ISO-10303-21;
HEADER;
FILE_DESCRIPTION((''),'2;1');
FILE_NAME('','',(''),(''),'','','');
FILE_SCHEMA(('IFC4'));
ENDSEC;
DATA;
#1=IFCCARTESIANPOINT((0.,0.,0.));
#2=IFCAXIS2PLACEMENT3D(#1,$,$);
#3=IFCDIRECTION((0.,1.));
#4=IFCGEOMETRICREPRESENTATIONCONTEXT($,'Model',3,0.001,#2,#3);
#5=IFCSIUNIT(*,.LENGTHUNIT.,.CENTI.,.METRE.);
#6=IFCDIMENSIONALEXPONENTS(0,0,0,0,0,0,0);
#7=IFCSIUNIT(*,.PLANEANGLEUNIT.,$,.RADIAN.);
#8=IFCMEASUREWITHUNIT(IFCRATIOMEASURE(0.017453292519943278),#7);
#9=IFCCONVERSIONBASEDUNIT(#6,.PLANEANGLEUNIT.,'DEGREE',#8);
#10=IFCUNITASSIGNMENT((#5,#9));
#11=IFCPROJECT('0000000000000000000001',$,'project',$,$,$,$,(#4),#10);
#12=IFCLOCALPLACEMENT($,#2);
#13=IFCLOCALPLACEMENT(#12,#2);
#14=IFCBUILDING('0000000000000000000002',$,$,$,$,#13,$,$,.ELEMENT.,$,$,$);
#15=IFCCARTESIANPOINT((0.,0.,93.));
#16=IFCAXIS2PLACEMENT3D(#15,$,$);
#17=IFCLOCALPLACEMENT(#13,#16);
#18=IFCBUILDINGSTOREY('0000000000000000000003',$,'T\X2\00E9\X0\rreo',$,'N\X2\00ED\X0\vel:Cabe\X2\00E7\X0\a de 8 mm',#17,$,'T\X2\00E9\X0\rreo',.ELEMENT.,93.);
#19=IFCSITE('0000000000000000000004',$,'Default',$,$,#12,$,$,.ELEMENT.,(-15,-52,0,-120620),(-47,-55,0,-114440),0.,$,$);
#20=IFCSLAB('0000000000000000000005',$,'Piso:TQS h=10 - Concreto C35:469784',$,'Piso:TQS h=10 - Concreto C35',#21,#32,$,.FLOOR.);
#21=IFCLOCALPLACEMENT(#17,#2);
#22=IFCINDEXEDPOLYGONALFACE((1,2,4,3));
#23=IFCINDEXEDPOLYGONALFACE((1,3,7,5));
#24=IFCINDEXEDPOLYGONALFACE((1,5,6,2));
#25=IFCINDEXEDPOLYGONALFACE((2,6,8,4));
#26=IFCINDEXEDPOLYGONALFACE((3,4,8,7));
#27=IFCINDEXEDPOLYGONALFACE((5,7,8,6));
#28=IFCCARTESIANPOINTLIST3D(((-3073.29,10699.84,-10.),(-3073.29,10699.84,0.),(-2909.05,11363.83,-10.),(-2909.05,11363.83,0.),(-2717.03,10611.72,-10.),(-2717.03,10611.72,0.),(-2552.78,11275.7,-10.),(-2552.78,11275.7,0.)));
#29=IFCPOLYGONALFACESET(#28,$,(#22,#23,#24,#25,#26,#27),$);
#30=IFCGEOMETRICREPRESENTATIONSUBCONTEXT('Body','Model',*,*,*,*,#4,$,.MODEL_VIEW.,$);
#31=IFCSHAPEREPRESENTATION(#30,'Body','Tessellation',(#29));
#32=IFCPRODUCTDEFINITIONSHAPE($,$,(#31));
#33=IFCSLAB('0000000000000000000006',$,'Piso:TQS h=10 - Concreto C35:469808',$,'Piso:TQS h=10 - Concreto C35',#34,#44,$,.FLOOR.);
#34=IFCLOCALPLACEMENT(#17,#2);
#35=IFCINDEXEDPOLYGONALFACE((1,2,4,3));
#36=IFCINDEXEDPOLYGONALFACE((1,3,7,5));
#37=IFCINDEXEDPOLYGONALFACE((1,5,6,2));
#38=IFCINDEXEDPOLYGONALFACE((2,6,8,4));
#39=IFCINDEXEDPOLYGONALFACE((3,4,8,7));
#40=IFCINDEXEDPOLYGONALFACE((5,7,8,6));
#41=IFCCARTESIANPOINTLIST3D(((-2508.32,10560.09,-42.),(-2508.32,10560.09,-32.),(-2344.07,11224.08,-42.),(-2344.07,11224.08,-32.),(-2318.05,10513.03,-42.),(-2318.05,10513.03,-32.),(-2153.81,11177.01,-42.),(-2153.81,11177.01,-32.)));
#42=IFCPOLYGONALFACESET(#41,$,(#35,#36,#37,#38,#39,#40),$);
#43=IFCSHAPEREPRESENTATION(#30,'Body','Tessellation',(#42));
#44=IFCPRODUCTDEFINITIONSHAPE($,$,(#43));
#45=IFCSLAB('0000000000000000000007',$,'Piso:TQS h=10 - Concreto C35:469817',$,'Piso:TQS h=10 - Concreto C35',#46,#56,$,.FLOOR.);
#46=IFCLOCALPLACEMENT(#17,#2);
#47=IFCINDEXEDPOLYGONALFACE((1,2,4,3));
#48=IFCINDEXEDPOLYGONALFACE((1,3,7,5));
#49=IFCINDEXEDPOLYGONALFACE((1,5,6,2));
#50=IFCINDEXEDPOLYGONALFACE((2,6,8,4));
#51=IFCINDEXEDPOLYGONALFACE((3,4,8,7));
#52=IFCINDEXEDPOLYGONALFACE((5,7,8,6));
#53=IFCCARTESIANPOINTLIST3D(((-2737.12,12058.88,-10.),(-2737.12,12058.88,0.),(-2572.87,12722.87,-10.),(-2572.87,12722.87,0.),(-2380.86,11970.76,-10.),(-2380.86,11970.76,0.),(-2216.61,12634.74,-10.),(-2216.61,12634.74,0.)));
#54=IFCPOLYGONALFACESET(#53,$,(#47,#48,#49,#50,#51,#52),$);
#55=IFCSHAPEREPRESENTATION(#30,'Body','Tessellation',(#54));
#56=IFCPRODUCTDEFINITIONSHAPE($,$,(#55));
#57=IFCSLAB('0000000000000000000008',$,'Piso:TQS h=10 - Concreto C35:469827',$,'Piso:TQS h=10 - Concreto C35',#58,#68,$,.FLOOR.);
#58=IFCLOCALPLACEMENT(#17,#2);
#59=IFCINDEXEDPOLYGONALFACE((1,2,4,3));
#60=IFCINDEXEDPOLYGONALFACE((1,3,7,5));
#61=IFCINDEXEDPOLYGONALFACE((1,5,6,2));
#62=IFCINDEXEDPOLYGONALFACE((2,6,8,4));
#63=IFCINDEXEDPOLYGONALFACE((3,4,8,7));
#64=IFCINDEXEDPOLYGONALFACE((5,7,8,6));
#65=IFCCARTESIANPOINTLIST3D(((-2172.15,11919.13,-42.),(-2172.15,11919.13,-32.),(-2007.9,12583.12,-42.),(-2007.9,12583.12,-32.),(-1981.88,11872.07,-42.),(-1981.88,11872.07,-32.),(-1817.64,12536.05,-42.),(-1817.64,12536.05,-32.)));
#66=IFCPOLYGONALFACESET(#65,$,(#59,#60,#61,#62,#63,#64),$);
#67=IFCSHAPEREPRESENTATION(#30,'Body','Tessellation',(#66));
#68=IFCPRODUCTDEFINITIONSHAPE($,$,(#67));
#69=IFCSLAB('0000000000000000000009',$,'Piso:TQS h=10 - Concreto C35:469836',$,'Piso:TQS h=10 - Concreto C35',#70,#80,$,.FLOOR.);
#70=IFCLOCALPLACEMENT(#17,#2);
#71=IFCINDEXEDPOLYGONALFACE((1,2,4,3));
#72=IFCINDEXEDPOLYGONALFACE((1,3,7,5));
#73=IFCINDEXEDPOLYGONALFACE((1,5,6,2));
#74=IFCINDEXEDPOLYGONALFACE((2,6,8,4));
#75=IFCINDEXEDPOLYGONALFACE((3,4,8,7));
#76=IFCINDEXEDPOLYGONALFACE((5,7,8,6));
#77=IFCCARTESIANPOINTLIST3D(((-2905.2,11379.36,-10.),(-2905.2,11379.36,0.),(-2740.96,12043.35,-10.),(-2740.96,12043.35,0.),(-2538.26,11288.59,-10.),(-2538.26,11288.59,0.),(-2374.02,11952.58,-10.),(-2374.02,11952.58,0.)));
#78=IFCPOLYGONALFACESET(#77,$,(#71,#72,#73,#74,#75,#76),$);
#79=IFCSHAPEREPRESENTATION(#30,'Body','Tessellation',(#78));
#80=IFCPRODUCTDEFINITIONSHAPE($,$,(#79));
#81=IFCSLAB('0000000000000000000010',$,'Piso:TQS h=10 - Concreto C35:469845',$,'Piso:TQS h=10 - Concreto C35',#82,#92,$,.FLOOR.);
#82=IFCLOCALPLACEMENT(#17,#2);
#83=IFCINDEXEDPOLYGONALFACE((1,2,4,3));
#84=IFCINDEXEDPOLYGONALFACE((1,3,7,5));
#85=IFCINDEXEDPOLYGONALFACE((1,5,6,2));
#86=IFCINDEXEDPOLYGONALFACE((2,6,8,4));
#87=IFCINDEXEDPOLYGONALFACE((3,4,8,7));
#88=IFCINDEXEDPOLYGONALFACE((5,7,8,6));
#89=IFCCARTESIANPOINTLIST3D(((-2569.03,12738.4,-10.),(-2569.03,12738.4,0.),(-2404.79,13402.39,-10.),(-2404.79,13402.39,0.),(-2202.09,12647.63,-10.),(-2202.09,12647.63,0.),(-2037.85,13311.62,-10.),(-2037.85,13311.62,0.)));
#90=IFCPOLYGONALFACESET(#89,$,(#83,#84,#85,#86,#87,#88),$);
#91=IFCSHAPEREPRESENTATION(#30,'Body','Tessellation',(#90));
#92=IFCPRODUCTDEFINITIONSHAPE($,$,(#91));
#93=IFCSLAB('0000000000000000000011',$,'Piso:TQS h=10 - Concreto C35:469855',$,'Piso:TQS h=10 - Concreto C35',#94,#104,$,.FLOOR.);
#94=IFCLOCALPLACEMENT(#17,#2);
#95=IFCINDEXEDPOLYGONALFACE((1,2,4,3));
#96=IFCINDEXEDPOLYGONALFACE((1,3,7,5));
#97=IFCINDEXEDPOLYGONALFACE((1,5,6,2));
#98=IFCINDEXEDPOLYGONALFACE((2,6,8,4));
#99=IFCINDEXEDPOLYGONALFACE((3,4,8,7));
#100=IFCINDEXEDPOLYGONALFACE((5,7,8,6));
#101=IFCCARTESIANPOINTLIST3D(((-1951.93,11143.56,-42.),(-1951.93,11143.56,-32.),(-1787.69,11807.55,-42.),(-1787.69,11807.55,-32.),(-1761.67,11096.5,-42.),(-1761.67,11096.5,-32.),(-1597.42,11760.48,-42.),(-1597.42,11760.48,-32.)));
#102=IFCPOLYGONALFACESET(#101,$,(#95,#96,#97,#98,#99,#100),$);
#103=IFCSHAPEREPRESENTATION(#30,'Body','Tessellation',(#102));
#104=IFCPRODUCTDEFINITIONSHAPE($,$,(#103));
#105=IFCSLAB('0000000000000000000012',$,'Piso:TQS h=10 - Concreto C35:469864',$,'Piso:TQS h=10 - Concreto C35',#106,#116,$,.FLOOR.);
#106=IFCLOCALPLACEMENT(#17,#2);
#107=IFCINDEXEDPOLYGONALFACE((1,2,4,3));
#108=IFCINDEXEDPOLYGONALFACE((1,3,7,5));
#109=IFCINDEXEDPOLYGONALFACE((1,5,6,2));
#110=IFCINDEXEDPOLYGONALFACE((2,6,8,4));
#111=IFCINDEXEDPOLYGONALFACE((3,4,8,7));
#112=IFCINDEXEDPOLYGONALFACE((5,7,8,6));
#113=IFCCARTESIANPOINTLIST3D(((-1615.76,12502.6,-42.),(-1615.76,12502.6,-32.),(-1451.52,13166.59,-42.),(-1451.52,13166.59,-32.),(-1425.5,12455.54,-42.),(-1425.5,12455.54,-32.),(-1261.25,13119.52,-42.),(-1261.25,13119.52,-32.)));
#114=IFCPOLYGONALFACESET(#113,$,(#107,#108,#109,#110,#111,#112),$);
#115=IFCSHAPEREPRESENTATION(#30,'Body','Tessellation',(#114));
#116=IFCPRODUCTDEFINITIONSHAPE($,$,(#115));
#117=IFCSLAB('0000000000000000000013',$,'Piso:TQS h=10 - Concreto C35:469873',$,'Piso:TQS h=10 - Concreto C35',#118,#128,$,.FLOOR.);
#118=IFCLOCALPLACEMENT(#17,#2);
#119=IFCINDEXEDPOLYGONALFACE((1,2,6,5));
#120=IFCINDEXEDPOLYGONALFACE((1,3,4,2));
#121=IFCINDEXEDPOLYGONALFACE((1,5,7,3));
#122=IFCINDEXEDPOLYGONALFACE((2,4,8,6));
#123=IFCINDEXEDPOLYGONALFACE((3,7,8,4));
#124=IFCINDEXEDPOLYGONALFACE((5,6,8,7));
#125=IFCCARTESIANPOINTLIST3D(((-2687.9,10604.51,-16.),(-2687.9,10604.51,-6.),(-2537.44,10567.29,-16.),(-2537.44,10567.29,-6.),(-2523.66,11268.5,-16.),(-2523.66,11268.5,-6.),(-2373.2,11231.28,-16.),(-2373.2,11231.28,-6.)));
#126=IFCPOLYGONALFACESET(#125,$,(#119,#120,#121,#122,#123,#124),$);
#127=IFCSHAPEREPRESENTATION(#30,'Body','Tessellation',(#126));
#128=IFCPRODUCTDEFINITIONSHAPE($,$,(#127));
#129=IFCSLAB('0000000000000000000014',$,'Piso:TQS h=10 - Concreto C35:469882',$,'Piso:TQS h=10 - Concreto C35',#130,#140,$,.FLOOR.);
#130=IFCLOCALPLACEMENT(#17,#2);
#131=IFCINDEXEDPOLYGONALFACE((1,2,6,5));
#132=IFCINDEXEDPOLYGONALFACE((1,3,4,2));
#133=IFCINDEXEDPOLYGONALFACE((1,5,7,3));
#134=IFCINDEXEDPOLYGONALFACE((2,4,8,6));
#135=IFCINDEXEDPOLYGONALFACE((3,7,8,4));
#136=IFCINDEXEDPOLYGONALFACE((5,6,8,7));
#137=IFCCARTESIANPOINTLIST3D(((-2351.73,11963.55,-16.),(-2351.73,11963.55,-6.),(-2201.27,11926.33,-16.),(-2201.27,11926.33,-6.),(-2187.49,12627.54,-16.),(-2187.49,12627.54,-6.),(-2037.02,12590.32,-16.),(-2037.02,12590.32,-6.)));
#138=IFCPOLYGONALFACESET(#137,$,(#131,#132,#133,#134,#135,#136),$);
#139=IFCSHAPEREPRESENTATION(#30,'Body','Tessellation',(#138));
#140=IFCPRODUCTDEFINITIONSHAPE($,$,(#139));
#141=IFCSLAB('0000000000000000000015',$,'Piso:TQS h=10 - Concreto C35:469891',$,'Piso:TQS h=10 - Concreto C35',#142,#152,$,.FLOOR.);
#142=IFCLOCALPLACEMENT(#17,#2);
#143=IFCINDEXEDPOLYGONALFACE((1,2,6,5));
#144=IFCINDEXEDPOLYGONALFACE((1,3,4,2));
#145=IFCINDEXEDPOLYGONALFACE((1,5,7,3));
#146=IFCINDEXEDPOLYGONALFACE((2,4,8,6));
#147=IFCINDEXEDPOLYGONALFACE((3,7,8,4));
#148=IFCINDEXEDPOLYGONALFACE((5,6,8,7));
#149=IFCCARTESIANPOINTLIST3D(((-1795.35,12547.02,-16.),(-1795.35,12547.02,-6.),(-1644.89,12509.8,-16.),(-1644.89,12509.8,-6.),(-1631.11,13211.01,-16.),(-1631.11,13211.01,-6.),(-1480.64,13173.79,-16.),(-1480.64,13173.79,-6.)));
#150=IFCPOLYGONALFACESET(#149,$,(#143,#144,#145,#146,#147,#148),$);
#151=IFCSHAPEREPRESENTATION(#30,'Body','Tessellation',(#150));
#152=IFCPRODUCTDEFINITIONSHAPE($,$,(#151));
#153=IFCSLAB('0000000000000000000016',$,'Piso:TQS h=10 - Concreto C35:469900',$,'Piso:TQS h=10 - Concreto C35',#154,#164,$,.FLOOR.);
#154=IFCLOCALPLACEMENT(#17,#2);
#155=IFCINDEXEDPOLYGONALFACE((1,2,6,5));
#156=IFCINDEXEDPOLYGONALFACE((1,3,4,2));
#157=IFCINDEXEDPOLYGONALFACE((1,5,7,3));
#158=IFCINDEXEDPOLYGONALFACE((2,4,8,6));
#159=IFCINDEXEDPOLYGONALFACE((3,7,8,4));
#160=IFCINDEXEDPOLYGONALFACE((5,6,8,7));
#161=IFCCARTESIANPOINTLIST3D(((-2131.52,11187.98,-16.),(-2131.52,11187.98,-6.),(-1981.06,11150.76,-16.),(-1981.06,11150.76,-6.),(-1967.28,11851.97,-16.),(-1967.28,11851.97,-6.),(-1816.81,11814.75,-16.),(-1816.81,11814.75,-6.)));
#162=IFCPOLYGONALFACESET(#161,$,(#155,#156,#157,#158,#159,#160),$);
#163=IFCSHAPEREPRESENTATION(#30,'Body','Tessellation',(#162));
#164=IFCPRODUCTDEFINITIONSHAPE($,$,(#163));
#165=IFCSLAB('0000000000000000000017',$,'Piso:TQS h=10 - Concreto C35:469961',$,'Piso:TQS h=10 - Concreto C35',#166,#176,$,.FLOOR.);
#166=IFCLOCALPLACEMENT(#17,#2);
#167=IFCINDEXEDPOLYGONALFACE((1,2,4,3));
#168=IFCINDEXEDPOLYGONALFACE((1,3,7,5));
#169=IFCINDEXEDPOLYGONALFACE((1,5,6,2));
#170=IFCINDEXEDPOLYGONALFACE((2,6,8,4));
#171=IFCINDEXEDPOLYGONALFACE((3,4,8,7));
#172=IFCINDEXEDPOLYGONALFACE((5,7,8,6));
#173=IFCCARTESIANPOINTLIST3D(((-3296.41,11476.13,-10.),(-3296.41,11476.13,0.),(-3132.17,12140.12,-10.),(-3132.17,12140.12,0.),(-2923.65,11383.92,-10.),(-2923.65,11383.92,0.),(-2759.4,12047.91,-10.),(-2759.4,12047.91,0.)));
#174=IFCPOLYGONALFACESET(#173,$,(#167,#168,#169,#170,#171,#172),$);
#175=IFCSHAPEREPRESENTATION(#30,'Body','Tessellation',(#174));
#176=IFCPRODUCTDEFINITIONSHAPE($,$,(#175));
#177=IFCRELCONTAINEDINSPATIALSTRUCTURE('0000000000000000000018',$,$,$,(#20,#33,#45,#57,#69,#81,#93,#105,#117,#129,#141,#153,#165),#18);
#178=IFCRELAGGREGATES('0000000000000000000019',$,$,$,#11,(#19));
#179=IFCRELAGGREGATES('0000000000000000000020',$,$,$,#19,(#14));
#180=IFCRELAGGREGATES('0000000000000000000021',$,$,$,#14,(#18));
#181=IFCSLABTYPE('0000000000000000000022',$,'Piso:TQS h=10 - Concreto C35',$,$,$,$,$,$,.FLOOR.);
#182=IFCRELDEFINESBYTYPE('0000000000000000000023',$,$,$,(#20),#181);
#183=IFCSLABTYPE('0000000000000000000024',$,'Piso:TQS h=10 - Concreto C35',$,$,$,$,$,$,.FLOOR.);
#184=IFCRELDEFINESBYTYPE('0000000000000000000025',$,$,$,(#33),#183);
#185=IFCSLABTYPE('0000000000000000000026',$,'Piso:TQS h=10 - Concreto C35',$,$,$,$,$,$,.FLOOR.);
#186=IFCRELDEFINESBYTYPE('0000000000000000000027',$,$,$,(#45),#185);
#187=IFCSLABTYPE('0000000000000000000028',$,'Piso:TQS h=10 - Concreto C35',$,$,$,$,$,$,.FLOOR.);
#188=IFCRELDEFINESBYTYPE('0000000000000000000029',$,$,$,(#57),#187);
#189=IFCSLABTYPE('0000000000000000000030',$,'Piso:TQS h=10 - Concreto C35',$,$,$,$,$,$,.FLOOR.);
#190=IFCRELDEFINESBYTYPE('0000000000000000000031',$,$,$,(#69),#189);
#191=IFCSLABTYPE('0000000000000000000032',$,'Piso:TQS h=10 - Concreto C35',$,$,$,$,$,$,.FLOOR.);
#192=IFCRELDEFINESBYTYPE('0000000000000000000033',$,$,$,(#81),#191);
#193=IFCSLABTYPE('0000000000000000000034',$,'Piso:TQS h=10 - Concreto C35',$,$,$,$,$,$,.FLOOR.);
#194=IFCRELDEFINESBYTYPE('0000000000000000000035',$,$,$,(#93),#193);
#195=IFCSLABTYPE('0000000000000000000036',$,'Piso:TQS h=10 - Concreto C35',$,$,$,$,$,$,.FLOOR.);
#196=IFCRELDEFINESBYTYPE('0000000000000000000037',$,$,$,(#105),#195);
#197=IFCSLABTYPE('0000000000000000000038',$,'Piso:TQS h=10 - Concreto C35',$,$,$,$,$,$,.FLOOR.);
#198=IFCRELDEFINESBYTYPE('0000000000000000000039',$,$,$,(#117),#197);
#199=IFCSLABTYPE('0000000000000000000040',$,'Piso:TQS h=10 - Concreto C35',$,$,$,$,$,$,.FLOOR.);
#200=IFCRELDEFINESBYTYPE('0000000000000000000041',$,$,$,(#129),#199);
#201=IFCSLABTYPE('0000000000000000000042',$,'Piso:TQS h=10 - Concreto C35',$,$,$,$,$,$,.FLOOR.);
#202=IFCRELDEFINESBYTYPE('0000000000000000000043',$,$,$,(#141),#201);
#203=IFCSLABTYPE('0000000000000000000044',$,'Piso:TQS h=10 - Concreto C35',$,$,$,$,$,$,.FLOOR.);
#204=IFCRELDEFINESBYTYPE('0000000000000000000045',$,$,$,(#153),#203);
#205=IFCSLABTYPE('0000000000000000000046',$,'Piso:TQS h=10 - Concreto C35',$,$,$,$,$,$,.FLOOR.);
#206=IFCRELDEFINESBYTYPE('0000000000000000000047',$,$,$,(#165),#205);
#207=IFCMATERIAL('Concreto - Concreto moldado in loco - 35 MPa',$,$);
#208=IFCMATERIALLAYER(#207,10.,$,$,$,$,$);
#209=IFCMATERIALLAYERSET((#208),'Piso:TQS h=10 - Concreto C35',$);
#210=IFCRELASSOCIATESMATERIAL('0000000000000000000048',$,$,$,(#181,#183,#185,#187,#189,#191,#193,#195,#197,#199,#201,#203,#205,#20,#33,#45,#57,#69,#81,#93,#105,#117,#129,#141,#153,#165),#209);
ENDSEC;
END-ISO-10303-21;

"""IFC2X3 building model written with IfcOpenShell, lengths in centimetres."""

from ifc_helpers import new_model, entity, si_unit, converted_unit, direction, frame, frame_2d, origin, origin_2d_with_axis, place, context, subcontext, project, spatial, rectangle, extrude, material, layer, layer_set, layer_usage, type_object, element, save


model = new_model("IFC2X3")

# Units and contexts
model_context = context("Model", 3, precision=0.001, world=origin(), true_north=direction((0.0, 1.0)))
body_context = subcontext(model_context, "Body", "Model", "MODEL_VIEW")
ifc_project = project(units=[si_unit("LENGTHUNIT", "METRE", prefix="CENTI"), converted_unit("PLANEANGLEUNIT", "DEGREE", entity("IfcRatioMeasure", 0.017453292519943278), si_unit("PLANEANGLEUNIT", "RADIAN"), dimensions=[0, 0, 0, 0, 0, 0, 0])], contexts=[model_context])

# Site, building, storey
site_placement = place(None, origin())
site = spatial("IfcSite", under=ifc_project, at=site_placement, Name="Default", CompositionType="ELEMENT", RefLatitude=(-15, -52, 0, -120620), RefLongitude=(-47, -55, 0, -114440), RefElevation=0.0)
building_placement = place(site_placement, origin())
building = spatial("IfcBuilding", under=site, at=building_placement, CompositionType="ELEMENT")
storey_placement = place(building_placement, frame((0.0, 0.0, 93.0)))
storey = spatial("IfcBuildingStorey", under=building, at=storey_placement, Name="Térreo", ObjectType="Nível:Cabeça de 8 mm", LongName="Térreo", CompositionType="ELEMENT", Elevation=93.0)

# Shared definitions
ifc_material = material(Name="Concreto - Concreto moldado in loco - 35 MPa")

# Slabs
ifc_layer = layer(ifc_material, 10.0)
ifc_layer_set = layer_set([ifc_layer], Name="Piso:TQS h=10 - Concreto C35")
ifc_layer_usage_1 = layer_usage(ifc_layer_set, "AXIS3", "POSITIVE", 0.0)
slab_type_1 = type_object("IfcSlabType", Name="Piso:TQS h=10 - Concreto C35", PredefinedType="FLOOR", material=ifc_layer_set)
slab_1_placement = place(storey_placement, origin())
element("IfcSlab", 1, at=slab_1_placement, inside=storey, type_object=slab_type_1, material=ifc_layer_usage_1, Name="Piso:TQS h=10 - Concreto C35:469784", ObjectType="Piso:TQS h=10 - Concreto C35", PredefinedType="FLOOR", context=body_context, shape_type="SweptSolid", body=[
    extrude(rectangle(XDim=684.0, YDim=367.0, at=frame_2d((0.0, 0.0), x_axis=(1.0, 0.0))), frame((-2813.04, 10987.77, 0.0), z_axis=(0.0, 0.0, -1.0), x_axis=(-0.240122, -0.970743, 0.0)), (0.0, 0.0, 1.0), 10.0),
])
ifc_layer_usage_2 = layer_usage(ifc_layer_set, "AXIS3", "POSITIVE", 0.0)
slab_type_2 = type_object("IfcSlabType", Name="Piso:TQS h=10 - Concreto C35", PredefinedType="FLOOR", material=ifc_layer_set)
slab_2_placement = place(storey_placement, origin())
element("IfcSlab", 2, at=slab_2_placement, inside=storey, type_object=slab_type_2, material=ifc_layer_usage_2, Name="Piso:TQS h=10 - Concreto C35:469808", ObjectType="Piso:TQS h=10 - Concreto C35", PredefinedType="FLOOR", context=body_context, shape_type="SweptSolid", body=[
    extrude(rectangle(XDim=684.0, YDim=196.0, at=origin_2d_with_axis()), frame((-2331.06, 10868.55, -32.0), z_axis=(0.0, 0.0, -1.0), x_axis=(-0.240122, -0.970743, 0.0)), (0.0, 0.0, 1.0), 10.0),
])
ifc_layer_usage_3 = layer_usage(ifc_layer_set, "AXIS3", "POSITIVE", 0.0)
slab_type_3 = type_object("IfcSlabType", Name="Piso:TQS h=10 - Concreto C35", PredefinedType="FLOOR", material=ifc_layer_set)
slab_3_placement = place(storey_placement, origin())
element("IfcSlab", 3, at=slab_3_placement, inside=storey, type_object=slab_type_3, material=ifc_layer_usage_3, Name="Piso:TQS h=10 - Concreto C35:469817", ObjectType="Piso:TQS h=10 - Concreto C35", PredefinedType="FLOOR", context=body_context, shape_type="SweptSolid", body=[
    extrude(rectangle(XDim=684.0, YDim=367.0, at=frame_2d((0.0, 0.0), x_axis=(1.0, 0.0))), frame((-2476.87, 12346.81, 0.0), z_axis=(0.0, 0.0, -1.0), x_axis=(-0.240122, -0.970743, 0.0)), (0.0, 0.0, 1.0), 10.0),
])
ifc_layer_usage_4 = layer_usage(ifc_layer_set, "AXIS3", "POSITIVE", 0.0)
slab_type_4 = type_object("IfcSlabType", Name="Piso:TQS h=10 - Concreto C35", PredefinedType="FLOOR", material=ifc_layer_set)
slab_4_placement = place(storey_placement, origin())
element("IfcSlab", 4, at=slab_4_placement, inside=storey, type_object=slab_type_4, material=ifc_layer_usage_4, Name="Piso:TQS h=10 - Concreto C35:469827", ObjectType="Piso:TQS h=10 - Concreto C35", PredefinedType="FLOOR", context=body_context, shape_type="SweptSolid", body=[
    extrude(rectangle(XDim=684.0, YDim=196.0, at=frame_2d((0.0, 0.0), x_axis=(1.0, 0.0))), frame((-1994.89, 12227.59, -32.0), z_axis=(0.0, 0.0, -1.0), x_axis=(-0.240122, -0.970743, 0.0)), (0.0, 0.0, 1.0), 10.0),
])
ifc_layer_usage_5 = layer_usage(ifc_layer_set, "AXIS3", "POSITIVE", 0.0)
slab_type_5 = type_object("IfcSlabType", Name="Piso:TQS h=10 - Concreto C35", PredefinedType="FLOOR", material=ifc_layer_set)
slab_5_placement = place(storey_placement, origin())
element("IfcSlab", 5, at=slab_5_placement, inside=storey, type_object=slab_type_5, material=ifc_layer_usage_5, Name="Piso:TQS h=10 - Concreto C35:469836", ObjectType="Piso:TQS h=10 - Concreto C35", PredefinedType="FLOOR", context=body_context, shape_type="SweptSolid", body=[
    extrude(rectangle(XDim=378.0, YDim=684.0, at=frame_2d((0.0, 0.0), x_axis=(1.0, 0.0))), frame((-2639.61, 11665.97, 0.0), z_axis=(0.0, 0.0, -1.0), x_axis=(0.970743, -0.240122, 0.0)), (0.0, 0.0, 1.0), 10.0),
])
ifc_layer_usage_6 = layer_usage(ifc_layer_set, "AXIS3", "POSITIVE", 0.0)
slab_type_6 = type_object("IfcSlabType", Name="Piso:TQS h=10 - Concreto C35", PredefinedType="FLOOR", material=ifc_layer_set)
slab_6_placement = place(storey_placement, origin())
element("IfcSlab", 6, at=slab_6_placement, inside=storey, type_object=slab_type_6, material=ifc_layer_usage_6, Name="Piso:TQS h=10 - Concreto C35:469845", ObjectType="Piso:TQS h=10 - Concreto C35", PredefinedType="FLOOR", context=body_context, shape_type="SweptSolid", body=[
    extrude(rectangle(XDim=378.0, YDim=684.0, at=frame_2d((0.0, 0.0), x_axis=(1.0, 0.0))), frame((-2303.44, 13025.01, 0.0), z_axis=(0.0, 0.0, -1.0), x_axis=(0.970743, -0.240122, 0.0)), (0.0, 0.0, 1.0), 10.0),
])
ifc_layer_usage_7 = layer_usage(ifc_layer_set, "AXIS3", "POSITIVE", 0.0)
slab_type_7 = type_object("IfcSlabType", Name="Piso:TQS h=10 - Concreto C35", PredefinedType="FLOOR", material=ifc_layer_set)
slab_7_placement = place(storey_placement, origin())
element("IfcSlab", 7, at=slab_7_placement, inside=storey, type_object=slab_type_7, material=ifc_layer_usage_7, Name="Piso:TQS h=10 - Concreto C35:469855", ObjectType="Piso:TQS h=10 - Concreto C35", PredefinedType="FLOOR", context=body_context, shape_type="SweptSolid", body=[
    extrude(rectangle(XDim=684.0, YDim=196.0, at=frame_2d((0.0, 0.0), x_axis=(1.0, 0.0))), frame((-1774.68, 11452.02, -32.0), z_axis=(0.0, 0.0, -1.0), x_axis=(-0.240122, -0.970743, 0.0)), (0.0, 0.0, 1.0), 10.0),
])
ifc_layer_usage_8 = layer_usage(ifc_layer_set, "AXIS3", "POSITIVE", 0.0)
slab_type_8 = type_object("IfcSlabType", Name="Piso:TQS h=10 - Concreto C35", PredefinedType="FLOOR", material=ifc_layer_set)
slab_8_placement = place(storey_placement, origin())
element("IfcSlab", 8, at=slab_8_placement, inside=storey, type_object=slab_type_8, material=ifc_layer_usage_8, Name="Piso:TQS h=10 - Concreto C35:469864", ObjectType="Piso:TQS h=10 - Concreto C35", PredefinedType="FLOOR", context=body_context, shape_type="SweptSolid", body=[
    extrude(rectangle(XDim=684.0, YDim=196.0, at=frame_2d((0.0, 0.0), x_axis=(1.0, 0.0))), frame((-1438.51, 12811.06, -32.0), z_axis=(0.0, 0.0, -1.0), x_axis=(-0.240122, -0.970743, 0.0)), (0.0, 0.0, 1.0), 10.0),
])
ifc_layer_usage_9 = layer_usage(ifc_layer_set, "AXIS3", "POSITIVE", 0.0)
slab_type_9 = type_object("IfcSlabType", Name="Piso:TQS h=10 - Concreto C35", PredefinedType="FLOOR", material=ifc_layer_set)
slab_9_placement = place(storey_placement, origin())
element("IfcSlab", 9, at=slab_9_placement, inside=storey, type_object=slab_type_9, material=ifc_layer_usage_9, Name="Piso:TQS h=10 - Concreto C35:469873", ObjectType="Piso:TQS h=10 - Concreto C35", PredefinedType="FLOOR", context=body_context, shape_type="SweptSolid", body=[
    extrude(rectangle(XDim=684.0, YDim=155.0, at=origin_2d_with_axis()), frame((-2530.55, 10917.9, -6.0), z_axis=(0.0, 0.0, -1.0), x_axis=(-0.240122, -0.970743, 0.0)), (0.0, 0.0, 1.0), 10.0),
])
ifc_layer_usage_10 = layer_usage(ifc_layer_set, "AXIS3", "POSITIVE", 0.0)
slab_type_10 = type_object("IfcSlabType", Name="Piso:TQS h=10 - Concreto C35", PredefinedType="FLOOR", material=ifc_layer_set)
slab_10_placement = place(storey_placement, origin())
element("IfcSlab", 10, at=slab_10_placement, inside=storey, type_object=slab_type_10, material=ifc_layer_usage_10, Name="Piso:TQS h=10 - Concreto C35:469882", ObjectType="Piso:TQS h=10 - Concreto C35", PredefinedType="FLOOR", context=body_context, shape_type="SweptSolid", body=[
    extrude(rectangle(XDim=684.0, YDim=155.0, at=frame_2d((0.0, 0.0), x_axis=(1.0, 0.0))), frame((-2194.38, 12276.94, -6.0), z_axis=(0.0, 0.0, -1.0), x_axis=(-0.240122, -0.970743, 0.0)), (0.0, 0.0, 1.0), 10.0),
])
ifc_layer_usage_11 = layer_usage(ifc_layer_set, "AXIS3", "POSITIVE", 0.0)
slab_type_11 = type_object("IfcSlabType", Name="Piso:TQS h=10 - Concreto C35", PredefinedType="FLOOR", material=ifc_layer_set)
slab_11_placement = place(storey_placement, origin())
element("IfcSlab", 11, at=slab_11_placement, inside=storey, type_object=slab_type_11, material=ifc_layer_usage_11, Name="Piso:TQS h=10 - Concreto C35:469891", ObjectType="Piso:TQS h=10 - Concreto C35", PredefinedType="FLOOR", context=body_context, shape_type="SweptSolid", body=[
    extrude(rectangle(XDim=684.0, YDim=155.0, at=frame_2d((0.0, 0.0), x_axis=(1.0, 0.0))), frame((-1638.0, 12860.41, -6.0), z_axis=(0.0, 0.0, -1.0), x_axis=(-0.240122, -0.970743, 0.0)), (0.0, 0.0, 1.0), 10.0),
])
ifc_layer_usage_12 = layer_usage(ifc_layer_set, "AXIS3", "POSITIVE", 0.0)
slab_type_12 = type_object("IfcSlabType", Name="Piso:TQS h=10 - Concreto C35", PredefinedType="FLOOR", material=ifc_layer_set)
slab_12_placement = place(storey_placement, origin())
element("IfcSlab", 12, at=slab_12_placement, inside=storey, type_object=slab_type_12, material=ifc_layer_usage_12, Name="Piso:TQS h=10 - Concreto C35:469900", ObjectType="Piso:TQS h=10 - Concreto C35", PredefinedType="FLOOR", context=body_context, shape_type="SweptSolid", body=[
    extrude(rectangle(XDim=684.0, YDim=155.0, at=origin_2d_with_axis()), frame((-1974.17, 11501.37, -6.0), z_axis=(0.0, 0.0, -1.0), x_axis=(-0.240122, -0.970743, 0.0)), (0.0, 0.0, 1.0), 10.0),
])
ifc_layer_usage_13 = layer_usage(ifc_layer_set, "AXIS3", "POSITIVE", 0.0)
slab_type_13 = type_object("IfcSlabType", Name="Piso:TQS h=10 - Concreto C35", PredefinedType="FLOOR", material=ifc_layer_set)
slab_13_placement = place(storey_placement, origin())
element("IfcSlab", 13, at=slab_13_placement, inside=storey, type_object=slab_type_13, material=ifc_layer_usage_13, Name="Piso:TQS h=10 - Concreto C35:469961", ObjectType="Piso:TQS h=10 - Concreto C35", PredefinedType="FLOOR", context=body_context, shape_type="SweptSolid", body=[
    extrude(rectangle(XDim=384.0, YDim=684.0, at=frame_2d((0.0, 0.0), x_axis=(1.0, 0.0))), frame((-3027.91, 11762.02, 0.0), z_axis=(0.0, 0.0, -1.0), x_axis=(0.970743, -0.240122, 0.0)), (0.0, 0.0, 1.0), 10.0),
])

save(model, "model.ifc")
